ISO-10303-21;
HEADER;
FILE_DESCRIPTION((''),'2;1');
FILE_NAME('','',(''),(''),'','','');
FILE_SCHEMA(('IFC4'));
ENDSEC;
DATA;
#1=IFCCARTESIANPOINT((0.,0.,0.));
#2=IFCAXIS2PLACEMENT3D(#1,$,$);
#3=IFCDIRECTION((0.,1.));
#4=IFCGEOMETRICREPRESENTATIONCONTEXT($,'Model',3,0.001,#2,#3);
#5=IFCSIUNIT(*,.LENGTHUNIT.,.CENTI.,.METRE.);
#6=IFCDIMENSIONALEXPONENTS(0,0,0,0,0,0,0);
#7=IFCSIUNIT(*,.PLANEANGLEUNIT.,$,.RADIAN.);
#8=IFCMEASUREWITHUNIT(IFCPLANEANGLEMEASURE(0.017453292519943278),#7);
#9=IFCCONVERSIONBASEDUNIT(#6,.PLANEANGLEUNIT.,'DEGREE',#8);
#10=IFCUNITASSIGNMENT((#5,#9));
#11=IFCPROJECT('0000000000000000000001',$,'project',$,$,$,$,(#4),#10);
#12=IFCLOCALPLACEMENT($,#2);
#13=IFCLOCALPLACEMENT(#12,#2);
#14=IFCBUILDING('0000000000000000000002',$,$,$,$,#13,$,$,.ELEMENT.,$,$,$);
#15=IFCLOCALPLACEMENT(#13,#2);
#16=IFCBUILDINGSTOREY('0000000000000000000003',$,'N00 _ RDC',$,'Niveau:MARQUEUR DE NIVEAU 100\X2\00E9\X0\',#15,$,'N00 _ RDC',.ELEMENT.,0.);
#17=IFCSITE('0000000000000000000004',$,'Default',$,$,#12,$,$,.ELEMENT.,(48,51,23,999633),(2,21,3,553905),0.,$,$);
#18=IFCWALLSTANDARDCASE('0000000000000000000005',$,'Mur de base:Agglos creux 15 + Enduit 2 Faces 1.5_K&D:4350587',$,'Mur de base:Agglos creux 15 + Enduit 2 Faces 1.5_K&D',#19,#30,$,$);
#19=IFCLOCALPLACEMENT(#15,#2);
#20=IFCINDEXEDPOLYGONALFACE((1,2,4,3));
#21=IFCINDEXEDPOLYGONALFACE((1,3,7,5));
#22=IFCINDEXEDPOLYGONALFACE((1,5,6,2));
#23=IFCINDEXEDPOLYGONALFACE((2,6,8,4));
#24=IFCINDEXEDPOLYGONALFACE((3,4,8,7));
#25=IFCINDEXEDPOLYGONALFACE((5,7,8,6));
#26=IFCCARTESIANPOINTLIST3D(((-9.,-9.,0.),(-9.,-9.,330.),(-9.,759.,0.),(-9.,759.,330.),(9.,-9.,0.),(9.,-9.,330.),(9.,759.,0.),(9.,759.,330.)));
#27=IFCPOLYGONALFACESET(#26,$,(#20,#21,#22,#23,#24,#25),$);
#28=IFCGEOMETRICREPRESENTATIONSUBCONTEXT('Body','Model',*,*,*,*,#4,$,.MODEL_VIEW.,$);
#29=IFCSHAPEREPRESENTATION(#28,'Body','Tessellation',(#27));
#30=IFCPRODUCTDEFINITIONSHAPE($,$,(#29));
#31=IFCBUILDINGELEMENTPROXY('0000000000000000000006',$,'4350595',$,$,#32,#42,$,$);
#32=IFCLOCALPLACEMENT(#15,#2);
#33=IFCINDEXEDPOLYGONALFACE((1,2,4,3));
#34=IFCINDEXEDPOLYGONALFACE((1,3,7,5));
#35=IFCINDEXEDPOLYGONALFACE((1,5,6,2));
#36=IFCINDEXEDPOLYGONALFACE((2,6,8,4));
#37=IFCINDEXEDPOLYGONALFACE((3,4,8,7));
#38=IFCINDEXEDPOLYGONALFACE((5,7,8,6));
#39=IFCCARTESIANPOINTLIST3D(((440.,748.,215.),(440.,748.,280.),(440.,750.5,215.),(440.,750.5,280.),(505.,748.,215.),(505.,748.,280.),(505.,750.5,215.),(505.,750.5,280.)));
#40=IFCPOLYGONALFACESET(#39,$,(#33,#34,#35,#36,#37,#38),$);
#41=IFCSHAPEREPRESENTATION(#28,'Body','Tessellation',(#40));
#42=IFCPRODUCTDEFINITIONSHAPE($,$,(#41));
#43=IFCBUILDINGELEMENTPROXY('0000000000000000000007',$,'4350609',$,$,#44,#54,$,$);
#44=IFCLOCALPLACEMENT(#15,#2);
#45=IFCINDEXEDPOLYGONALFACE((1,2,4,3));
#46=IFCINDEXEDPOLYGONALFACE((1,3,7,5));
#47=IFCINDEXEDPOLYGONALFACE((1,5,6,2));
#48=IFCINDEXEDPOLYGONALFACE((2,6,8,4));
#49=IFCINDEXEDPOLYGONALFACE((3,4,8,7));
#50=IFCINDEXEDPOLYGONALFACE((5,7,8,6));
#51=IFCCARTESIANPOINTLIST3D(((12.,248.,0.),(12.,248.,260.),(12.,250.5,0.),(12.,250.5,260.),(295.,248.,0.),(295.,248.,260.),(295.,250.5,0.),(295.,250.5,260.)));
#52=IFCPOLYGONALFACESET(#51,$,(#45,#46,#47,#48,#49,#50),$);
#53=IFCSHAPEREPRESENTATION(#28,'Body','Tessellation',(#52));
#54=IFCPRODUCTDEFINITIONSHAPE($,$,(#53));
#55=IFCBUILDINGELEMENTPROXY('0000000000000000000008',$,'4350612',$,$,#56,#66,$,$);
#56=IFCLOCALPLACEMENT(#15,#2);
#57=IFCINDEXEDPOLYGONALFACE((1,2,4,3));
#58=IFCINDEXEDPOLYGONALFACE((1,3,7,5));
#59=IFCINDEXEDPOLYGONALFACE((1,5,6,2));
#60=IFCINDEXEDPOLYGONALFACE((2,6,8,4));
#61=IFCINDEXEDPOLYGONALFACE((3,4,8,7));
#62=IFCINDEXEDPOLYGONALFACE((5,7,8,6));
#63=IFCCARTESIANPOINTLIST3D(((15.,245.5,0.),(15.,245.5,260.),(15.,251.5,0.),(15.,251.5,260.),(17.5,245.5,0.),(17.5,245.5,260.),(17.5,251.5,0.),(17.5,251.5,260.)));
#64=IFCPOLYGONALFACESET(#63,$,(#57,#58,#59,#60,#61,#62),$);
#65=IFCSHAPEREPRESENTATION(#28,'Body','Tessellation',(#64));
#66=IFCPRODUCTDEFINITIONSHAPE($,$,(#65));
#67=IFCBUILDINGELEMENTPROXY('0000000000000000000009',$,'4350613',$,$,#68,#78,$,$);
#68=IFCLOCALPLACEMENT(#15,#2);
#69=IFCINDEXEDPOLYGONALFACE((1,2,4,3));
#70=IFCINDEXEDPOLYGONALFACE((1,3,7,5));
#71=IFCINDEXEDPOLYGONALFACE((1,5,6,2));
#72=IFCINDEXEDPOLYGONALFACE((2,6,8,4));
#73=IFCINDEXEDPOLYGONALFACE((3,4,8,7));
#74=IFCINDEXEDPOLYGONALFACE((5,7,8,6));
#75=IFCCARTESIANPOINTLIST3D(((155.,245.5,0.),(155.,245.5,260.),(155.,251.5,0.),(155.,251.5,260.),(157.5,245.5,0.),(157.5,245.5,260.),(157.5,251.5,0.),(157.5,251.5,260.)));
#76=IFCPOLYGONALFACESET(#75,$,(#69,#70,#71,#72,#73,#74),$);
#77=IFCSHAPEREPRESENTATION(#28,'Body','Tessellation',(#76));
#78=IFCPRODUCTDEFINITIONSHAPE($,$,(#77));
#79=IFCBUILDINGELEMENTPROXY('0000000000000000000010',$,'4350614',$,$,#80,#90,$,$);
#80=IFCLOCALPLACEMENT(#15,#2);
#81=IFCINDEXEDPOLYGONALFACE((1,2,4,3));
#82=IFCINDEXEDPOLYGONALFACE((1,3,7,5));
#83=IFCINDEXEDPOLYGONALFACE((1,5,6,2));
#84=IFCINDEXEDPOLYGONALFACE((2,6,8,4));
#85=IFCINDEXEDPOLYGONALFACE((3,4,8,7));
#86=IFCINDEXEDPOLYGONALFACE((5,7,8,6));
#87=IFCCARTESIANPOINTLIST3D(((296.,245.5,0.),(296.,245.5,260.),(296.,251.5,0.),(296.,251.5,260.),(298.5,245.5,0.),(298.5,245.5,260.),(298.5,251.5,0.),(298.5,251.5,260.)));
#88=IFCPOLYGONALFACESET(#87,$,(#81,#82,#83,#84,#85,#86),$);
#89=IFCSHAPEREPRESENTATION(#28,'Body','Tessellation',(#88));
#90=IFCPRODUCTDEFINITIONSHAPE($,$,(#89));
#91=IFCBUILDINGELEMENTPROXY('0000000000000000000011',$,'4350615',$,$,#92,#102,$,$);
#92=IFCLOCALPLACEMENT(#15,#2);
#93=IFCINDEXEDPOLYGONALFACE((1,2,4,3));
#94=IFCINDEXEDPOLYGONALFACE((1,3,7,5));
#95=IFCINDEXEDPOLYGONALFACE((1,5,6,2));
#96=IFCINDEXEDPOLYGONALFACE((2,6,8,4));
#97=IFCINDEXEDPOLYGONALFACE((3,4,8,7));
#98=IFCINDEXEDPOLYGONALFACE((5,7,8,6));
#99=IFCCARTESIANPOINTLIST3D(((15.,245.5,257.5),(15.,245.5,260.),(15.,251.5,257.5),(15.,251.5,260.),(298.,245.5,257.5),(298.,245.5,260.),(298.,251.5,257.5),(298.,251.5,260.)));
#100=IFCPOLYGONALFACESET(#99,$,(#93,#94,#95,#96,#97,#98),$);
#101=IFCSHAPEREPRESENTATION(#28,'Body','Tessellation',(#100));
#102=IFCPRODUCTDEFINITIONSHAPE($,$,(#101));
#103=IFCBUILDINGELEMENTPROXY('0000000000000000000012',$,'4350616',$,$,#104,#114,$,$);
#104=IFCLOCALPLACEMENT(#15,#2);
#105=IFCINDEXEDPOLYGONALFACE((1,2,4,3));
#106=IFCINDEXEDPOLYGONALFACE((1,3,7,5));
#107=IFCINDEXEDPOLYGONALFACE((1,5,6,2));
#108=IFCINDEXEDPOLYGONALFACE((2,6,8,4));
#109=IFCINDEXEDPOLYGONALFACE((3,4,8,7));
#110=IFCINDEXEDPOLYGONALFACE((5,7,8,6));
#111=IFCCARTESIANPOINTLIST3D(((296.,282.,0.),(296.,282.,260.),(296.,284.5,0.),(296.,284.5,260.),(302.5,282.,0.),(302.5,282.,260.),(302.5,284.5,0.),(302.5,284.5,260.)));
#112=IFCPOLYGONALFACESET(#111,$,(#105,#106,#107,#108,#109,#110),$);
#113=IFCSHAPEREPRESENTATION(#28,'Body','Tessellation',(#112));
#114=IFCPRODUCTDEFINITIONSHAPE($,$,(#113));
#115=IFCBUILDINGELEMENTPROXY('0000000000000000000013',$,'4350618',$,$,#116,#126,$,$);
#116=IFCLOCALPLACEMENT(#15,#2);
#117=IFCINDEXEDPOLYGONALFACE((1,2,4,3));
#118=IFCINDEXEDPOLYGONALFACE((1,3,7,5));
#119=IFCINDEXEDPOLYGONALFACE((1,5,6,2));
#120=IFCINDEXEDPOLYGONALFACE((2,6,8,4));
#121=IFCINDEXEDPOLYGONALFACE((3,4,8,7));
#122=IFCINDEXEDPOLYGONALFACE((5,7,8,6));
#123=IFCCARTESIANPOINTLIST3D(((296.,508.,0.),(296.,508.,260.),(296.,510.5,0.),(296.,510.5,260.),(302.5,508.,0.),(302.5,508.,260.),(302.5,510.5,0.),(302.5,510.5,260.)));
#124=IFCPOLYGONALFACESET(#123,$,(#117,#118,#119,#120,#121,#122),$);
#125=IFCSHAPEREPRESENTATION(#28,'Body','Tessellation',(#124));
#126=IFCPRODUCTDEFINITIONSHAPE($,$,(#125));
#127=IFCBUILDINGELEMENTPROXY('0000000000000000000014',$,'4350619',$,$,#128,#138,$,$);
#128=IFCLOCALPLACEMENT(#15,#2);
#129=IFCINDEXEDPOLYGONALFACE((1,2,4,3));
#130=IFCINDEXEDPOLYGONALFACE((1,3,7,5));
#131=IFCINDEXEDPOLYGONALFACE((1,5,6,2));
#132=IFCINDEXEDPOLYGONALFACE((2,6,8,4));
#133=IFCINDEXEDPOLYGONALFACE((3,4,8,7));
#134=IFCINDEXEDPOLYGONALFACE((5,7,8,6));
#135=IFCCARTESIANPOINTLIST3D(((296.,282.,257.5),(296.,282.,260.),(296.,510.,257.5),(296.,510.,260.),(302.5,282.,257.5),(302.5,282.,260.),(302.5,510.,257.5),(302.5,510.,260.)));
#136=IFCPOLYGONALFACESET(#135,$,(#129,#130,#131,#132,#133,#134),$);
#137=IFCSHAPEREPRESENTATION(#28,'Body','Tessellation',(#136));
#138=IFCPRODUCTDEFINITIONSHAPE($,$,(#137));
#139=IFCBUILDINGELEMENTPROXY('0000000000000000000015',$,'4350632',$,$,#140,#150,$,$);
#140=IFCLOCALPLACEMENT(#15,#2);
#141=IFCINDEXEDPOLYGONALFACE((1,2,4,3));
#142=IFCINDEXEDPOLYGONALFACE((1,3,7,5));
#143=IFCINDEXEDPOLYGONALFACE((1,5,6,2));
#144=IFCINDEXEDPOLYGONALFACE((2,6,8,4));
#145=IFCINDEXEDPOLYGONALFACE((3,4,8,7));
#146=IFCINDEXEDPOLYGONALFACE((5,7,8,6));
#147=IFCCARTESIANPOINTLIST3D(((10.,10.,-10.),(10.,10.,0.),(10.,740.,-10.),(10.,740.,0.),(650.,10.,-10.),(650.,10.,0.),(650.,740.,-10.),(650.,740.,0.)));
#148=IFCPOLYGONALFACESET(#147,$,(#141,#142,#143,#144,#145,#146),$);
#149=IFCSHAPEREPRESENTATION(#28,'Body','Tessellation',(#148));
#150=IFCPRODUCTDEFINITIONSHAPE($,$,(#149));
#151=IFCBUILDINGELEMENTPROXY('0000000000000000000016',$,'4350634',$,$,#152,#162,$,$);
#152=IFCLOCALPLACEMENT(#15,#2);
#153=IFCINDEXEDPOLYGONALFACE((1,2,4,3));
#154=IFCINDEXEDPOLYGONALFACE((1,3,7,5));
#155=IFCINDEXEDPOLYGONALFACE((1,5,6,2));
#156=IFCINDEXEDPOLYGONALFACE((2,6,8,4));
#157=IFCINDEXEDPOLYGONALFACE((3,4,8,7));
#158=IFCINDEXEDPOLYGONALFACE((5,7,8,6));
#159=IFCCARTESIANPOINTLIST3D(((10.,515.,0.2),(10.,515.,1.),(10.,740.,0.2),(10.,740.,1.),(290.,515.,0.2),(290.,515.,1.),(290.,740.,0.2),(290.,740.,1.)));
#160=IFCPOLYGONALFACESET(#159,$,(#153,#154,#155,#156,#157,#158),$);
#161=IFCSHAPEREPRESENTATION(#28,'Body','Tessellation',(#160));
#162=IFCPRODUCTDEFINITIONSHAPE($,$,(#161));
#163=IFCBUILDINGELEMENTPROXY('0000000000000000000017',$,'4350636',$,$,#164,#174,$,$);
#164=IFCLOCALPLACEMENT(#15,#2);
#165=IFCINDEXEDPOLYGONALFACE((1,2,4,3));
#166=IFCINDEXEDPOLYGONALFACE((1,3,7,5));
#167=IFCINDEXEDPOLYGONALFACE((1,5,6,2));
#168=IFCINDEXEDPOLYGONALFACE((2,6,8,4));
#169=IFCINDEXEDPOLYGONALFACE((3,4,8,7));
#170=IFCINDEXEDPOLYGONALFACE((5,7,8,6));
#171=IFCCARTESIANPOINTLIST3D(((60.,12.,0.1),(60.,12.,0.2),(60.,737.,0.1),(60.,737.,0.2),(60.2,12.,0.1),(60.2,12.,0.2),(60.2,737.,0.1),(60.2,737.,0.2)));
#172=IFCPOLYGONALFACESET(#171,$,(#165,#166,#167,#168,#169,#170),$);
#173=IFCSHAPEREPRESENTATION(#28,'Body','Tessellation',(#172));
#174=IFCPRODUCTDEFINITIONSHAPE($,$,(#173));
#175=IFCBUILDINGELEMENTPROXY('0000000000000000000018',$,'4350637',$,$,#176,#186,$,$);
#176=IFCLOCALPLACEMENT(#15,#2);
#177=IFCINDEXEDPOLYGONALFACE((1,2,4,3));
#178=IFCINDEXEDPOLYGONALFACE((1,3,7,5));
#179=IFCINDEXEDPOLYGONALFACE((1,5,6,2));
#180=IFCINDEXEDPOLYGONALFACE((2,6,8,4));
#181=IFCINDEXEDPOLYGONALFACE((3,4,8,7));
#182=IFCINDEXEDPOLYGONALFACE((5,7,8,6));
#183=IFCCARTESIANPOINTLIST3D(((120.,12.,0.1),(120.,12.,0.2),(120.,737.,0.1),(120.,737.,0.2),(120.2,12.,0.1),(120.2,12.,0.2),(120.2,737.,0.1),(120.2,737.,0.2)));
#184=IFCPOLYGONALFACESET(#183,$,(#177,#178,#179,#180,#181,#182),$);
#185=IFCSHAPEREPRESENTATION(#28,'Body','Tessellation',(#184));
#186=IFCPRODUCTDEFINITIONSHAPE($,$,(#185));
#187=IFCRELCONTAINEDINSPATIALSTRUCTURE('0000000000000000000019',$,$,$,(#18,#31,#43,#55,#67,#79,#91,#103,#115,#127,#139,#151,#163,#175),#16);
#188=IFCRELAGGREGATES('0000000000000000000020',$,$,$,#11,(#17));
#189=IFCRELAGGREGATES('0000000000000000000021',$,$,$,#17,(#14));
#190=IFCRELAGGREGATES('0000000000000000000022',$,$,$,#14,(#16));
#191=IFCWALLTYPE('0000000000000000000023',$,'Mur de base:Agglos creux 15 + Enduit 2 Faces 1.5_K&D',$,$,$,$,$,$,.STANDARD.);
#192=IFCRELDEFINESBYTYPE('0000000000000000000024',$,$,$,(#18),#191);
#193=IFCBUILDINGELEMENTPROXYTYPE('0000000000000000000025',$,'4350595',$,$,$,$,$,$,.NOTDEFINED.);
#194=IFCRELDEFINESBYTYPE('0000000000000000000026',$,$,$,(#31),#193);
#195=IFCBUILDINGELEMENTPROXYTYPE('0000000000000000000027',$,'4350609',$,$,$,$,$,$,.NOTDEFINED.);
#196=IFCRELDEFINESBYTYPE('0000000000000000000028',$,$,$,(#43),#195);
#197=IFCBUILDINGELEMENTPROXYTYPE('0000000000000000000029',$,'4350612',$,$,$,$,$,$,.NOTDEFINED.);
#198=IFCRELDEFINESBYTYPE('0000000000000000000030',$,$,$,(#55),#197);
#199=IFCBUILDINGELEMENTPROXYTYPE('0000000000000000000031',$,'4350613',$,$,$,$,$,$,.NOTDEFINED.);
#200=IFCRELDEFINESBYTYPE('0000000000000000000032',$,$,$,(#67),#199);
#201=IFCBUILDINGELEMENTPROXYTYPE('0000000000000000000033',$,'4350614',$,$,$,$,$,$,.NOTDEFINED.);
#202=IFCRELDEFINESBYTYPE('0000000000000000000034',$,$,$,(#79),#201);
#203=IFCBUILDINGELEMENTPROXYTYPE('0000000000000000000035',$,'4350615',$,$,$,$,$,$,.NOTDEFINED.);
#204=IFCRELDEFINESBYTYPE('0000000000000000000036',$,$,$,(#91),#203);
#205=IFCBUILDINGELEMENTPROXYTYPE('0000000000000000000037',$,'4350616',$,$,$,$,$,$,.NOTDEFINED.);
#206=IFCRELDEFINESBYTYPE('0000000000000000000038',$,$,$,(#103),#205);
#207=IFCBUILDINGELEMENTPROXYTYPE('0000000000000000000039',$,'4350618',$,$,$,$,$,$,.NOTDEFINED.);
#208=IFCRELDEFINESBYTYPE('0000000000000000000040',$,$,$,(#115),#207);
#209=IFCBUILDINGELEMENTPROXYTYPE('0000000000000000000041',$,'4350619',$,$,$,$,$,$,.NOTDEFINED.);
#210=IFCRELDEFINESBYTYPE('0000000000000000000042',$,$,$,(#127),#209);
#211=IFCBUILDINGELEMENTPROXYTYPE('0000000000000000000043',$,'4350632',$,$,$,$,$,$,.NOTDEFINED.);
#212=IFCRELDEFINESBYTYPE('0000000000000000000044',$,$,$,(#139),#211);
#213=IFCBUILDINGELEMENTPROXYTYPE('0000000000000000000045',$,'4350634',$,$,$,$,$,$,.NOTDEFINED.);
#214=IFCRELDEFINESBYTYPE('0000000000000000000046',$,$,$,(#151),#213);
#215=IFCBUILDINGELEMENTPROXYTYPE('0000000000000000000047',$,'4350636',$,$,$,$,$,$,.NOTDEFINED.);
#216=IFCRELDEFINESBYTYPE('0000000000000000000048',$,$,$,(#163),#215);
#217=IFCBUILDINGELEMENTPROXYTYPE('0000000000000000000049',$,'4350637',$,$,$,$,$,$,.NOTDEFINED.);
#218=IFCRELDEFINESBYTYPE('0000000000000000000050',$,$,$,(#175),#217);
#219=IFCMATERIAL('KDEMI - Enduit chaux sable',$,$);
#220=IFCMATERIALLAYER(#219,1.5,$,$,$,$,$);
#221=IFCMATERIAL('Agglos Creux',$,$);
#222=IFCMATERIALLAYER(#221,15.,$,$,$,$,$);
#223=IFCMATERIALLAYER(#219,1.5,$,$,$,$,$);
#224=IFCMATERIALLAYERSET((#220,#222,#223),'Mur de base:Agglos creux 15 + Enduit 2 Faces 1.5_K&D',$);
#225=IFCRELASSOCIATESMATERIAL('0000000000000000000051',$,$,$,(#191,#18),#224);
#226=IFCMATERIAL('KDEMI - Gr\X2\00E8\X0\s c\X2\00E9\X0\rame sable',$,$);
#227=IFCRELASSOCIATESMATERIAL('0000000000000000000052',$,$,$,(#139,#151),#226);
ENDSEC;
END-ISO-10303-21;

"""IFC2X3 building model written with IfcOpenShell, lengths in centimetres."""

from ifc_helpers import new_model, entity, si_unit, converted_unit, direction, frame, frame_2d, origin, origin_2d_with_axis, place, context, subcontext, project, spatial, rectangle, extrude, material, layer, layer_set, layer_usage, type_object, element, save


model = new_model("IFC2X3")

# Units and contexts
model_context = context("Model", 3, precision=0.001, world=origin(), true_north=direction((0.0, 1.0)))
body_context = subcontext(model_context, "Body", "Model", "MODEL_VIEW")
ifc_project = project(units=[si_unit("LENGTHUNIT", "METRE", prefix="CENTI"), converted_unit("PLANEANGLEUNIT", "DEGREE", entity("IfcPlaneAngleMeasure", 0.017453292519943278), si_unit("PLANEANGLEUNIT", "RADIAN"), dimensions=[0, 0, 0, 0, 0, 0, 0])], contexts=[model_context])

# Site, building, storey
site_placement = place(None, origin())
site = spatial("IfcSite", under=ifc_project, at=site_placement, Name="Default", CompositionType="ELEMENT", RefLatitude=(48, 51, 23, 999633), RefLongitude=(2, 21, 3, 553905), RefElevation=0.0)
building_placement = place(site_placement, origin())
building = spatial("IfcBuilding", under=site, at=building_placement, CompositionType="ELEMENT")
storey_placement = place(building_placement, origin())
storey = spatial("IfcBuildingStorey", under=building, at=storey_placement, Name="N00 _ RDC", ObjectType="Niveau:MARQUEUR DE NIVEAU 100é", LongName="N00 _ RDC", CompositionType="ELEMENT", Elevation=0.0)

# Wall
ifc_material_1 = material(Name="KDEMI - Enduit chaux sable")
ifc_layer_1 = layer(ifc_material_1, 1.5)
ifc_material_2 = material(Name="Agglos Creux")
ifc_layer_2 = layer(ifc_material_2, 15.0)
ifc_layer_3 = layer(ifc_material_1, 1.5)
ifc_layer_set = layer_set([ifc_layer_1, ifc_layer_2, ifc_layer_3], Name="Mur de base:Agglos creux 15 + Enduit 2 Faces 1.5_K&D")
ifc_layer_usage = layer_usage(ifc_layer_set, "AXIS2", "NEGATIVE", 9.0)
wall_type = type_object("IfcWallType", Name="Mur de base:Agglos creux 15 + Enduit 2 Faces 1.5_K&D", PredefinedType="STANDARD", material=ifc_layer_set)
wall_placement = place(storey_placement, frame((0.0, -9.0, 0.0), z_axis=(0.0, 0.0, 1.0), x_axis=(0.0, 1.0, 0.0)))
element("IfcWallStandardCase", 1, at=wall_placement, inside=storey, type_object=wall_type, material=ifc_layer_usage, Name="Mur de base:Agglos creux 15 + Enduit 2 Faces 1.5_K&D:4350587", ObjectType="Mur de base:Agglos creux 15 + Enduit 2 Faces 1.5_K&D", context=body_context, shape_type="SweptSolid", body=[
    extrude(rectangle(XDim=768.0, YDim=18.0, at=frame_2d((384.0, 0.0), x_axis=(-1.0, 0.0))), origin(), (0.0, 0.0, 1.0), 330.0),
])

# Building element proxies
building_element_proxy_type_1 = type_object("IfcBuildingElementProxyType", Name="4350595", PredefinedType="NOTDEFINED")
proxy_1_placement = place(storey_placement, origin())
element("IfcBuildingElementProxy", 2, at=proxy_1_placement, inside=storey, type_object=building_element_proxy_type_1, Name="4350595", context=body_context, shape_type="SweptSolid", body=[
    extrude(rectangle(XDim=65.0, YDim=2.5, at=frame_2d((0.0, 0.0), x_axis=(1.0, 0.0))), frame((472.5, 749.25, 215.0)), (0.0, 0.0, 1.0), 65.0),
])
building_element_proxy_type_2 = type_object("IfcBuildingElementProxyType", Name="4350609", PredefinedType="NOTDEFINED")
proxy_2_placement = place(storey_placement, origin())
element("IfcBuildingElementProxy", 3, at=proxy_2_placement, inside=storey, type_object=building_element_proxy_type_2, Name="4350609", context=body_context, shape_type="SweptSolid", body=[
    extrude(rectangle(XDim=283.0, YDim=2.5, at=frame_2d((0.0, 0.0), x_axis=(1.0, 0.0))), frame((153.5, 249.25, 0.0)), (0.0, 0.0, 1.0), 260.0),
])
building_element_proxy_type_3 = type_object("IfcBuildingElementProxyType", Name="4350612", PredefinedType="NOTDEFINED")
proxy_3_placement = place(storey_placement, origin())
element("IfcBuildingElementProxy", 4, at=proxy_3_placement, inside=storey, type_object=building_element_proxy_type_3, Name="4350612", context=body_context, shape_type="SweptSolid", body=[
    extrude(rectangle(XDim=2.5, YDim=6.0, at=frame_2d((0.0, 0.0), x_axis=(1.0, 0.0))), frame((16.25, 248.5, 0.0)), (0.0, 0.0, 1.0), 260.0),
])
building_element_proxy_type_4 = type_object("IfcBuildingElementProxyType", Name="4350613", PredefinedType="NOTDEFINED")
proxy_4_placement = place(storey_placement, origin())
element("IfcBuildingElementProxy", 5, at=proxy_4_placement, inside=storey, type_object=building_element_proxy_type_4, Name="4350613", context=body_context, shape_type="SweptSolid", body=[
    extrude(rectangle(XDim=2.5, YDim=6.0, at=frame_2d((0.0, 0.0), x_axis=(1.0, 0.0))), frame((156.25, 248.5, 0.0)), (0.0, 0.0, 1.0), 260.0),
])
building_element_proxy_type_5 = type_object("IfcBuildingElementProxyType", Name="4350614", PredefinedType="NOTDEFINED")
proxy_5_placement = place(storey_placement, origin())
element("IfcBuildingElementProxy", 6, at=proxy_5_placement, inside=storey, type_object=building_element_proxy_type_5, Name="4350614", context=body_context, shape_type="SweptSolid", body=[
    extrude(rectangle(XDim=2.5, YDim=6.0, at=frame_2d((0.0, 0.0), x_axis=(1.0, 0.0))), frame((297.25, 248.5, 0.0)), (0.0, 0.0, 1.0), 260.0),
])
building_element_proxy_type_6 = type_object("IfcBuildingElementProxyType", Name="4350615", PredefinedType="NOTDEFINED")
proxy_6_placement = place(storey_placement, origin())
element("IfcBuildingElementProxy", 7, at=proxy_6_placement, inside=storey, type_object=building_element_proxy_type_6, Name="4350615", context=body_context, shape_type="SweptSolid", body=[
    extrude(rectangle(XDim=283.0, YDim=6.0, at=frame_2d((0.0, 0.0), x_axis=(1.0, 0.0))), frame((156.5, 248.5, 257.5)), (0.0, 0.0, 1.0), 2.5),
])
building_element_proxy_type_7 = type_object("IfcBuildingElementProxyType", Name="4350616", PredefinedType="NOTDEFINED")
proxy_7_placement = place(storey_placement, origin())
element("IfcBuildingElementProxy", 8, at=proxy_7_placement, inside=storey, type_object=building_element_proxy_type_7, Name="4350616", context=body_context, shape_type="SweptSolid", body=[
    extrude(rectangle(XDim=6.5, YDim=2.5, at=frame_2d((0.0, 0.0), x_axis=(1.0, 0.0))), frame((299.25, 283.25, 0.0)), (0.0, 0.0, 1.0), 260.0),
])
building_element_proxy_type_8 = type_object("IfcBuildingElementProxyType", Name="4350618", PredefinedType="NOTDEFINED")
proxy_8_placement = place(storey_placement, origin())
element("IfcBuildingElementProxy", 9, at=proxy_8_placement, inside=storey, type_object=building_element_proxy_type_8, Name="4350618", context=body_context, shape_type="SweptSolid", body=[
    extrude(rectangle(XDim=6.5, YDim=2.5, at=frame_2d((0.0, 0.0), x_axis=(1.0, 0.0))), frame((299.25, 509.25, 0.0)), (0.0, 0.0, 1.0), 260.0),
])
building_element_proxy_type_9 = type_object("IfcBuildingElementProxyType", Name="4350619", PredefinedType="NOTDEFINED")
proxy_9_placement = place(storey_placement, origin())
element("IfcBuildingElementProxy", 10, at=proxy_9_placement, inside=storey, type_object=building_element_proxy_type_9, Name="4350619", context=body_context, shape_type="SweptSolid", body=[
    extrude(rectangle(XDim=6.5, YDim=228.0, at=frame_2d((0.0, 0.0), x_axis=(1.0, 0.0))), frame((299.25, 396.0, 257.5)), (0.0, 0.0, 1.0), 2.5),
])
ifc_material_3 = material(Name="KDEMI - Grès cérame sable")
building_element_proxy_type_10 = type_object("IfcBuildingElementProxyType", Name="4350632", PredefinedType="NOTDEFINED")
proxy_10_placement = place(storey_placement, origin())
element("IfcBuildingElementProxy", 11, at=proxy_10_placement, inside=storey, type_object=building_element_proxy_type_10, material=ifc_material_3, Name="4350632", context=body_context, shape_type="SweptSolid", body=[
    extrude(rectangle(XDim=640.0, YDim=730.0, at=origin_2d_with_axis()), frame((330.0, 375.0, -10.0)), (0.0, 0.0, 1.0), 10.0),
])
building_element_proxy_type_11 = type_object("IfcBuildingElementProxyType", Name="4350634", PredefinedType="NOTDEFINED")
proxy_11_placement = place(storey_placement, origin())
element("IfcBuildingElementProxy", 12, at=proxy_11_placement, inside=storey, type_object=building_element_proxy_type_11, material=ifc_material_3, Name="4350634", context=body_context, shape_type="SweptSolid", body=[
    extrude(rectangle(XDim=280.0, YDim=225.0, at=frame_2d((0.0, 0.0), x_axis=(1.0, 0.0))), frame((150.0, 627.5, 0.2)), (0.0, 0.0, 1.0), 0.8),
])
building_element_proxy_type_12 = type_object("IfcBuildingElementProxyType", Name="4350636", PredefinedType="NOTDEFINED")
proxy_12_placement = place(storey_placement, origin())
element("IfcBuildingElementProxy", 13, at=proxy_12_placement, inside=storey, type_object=building_element_proxy_type_12, Name="4350636", context=body_context, shape_type="SweptSolid", body=[
    extrude(rectangle(XDim=0.2, YDim=725.0, at=frame_2d((0.0, 0.0), x_axis=(1.0, 0.0))), frame((60.1, 374.5, 0.1)), (0.0, 0.0, 1.0), 0.1),
])
building_element_proxy_type_13 = type_object("IfcBuildingElementProxyType", Name="4350637", PredefinedType="NOTDEFINED")
proxy_13_placement = place(storey_placement, origin())
element("IfcBuildingElementProxy", 14, at=proxy_13_placement, inside=storey, type_object=building_element_proxy_type_13, Name="4350637", context=body_context, shape_type="SweptSolid", body=[
    extrude(rectangle(XDim=0.2, YDim=725.0, at=frame_2d((0.0, 0.0), x_axis=(1.0, 0.0))), frame((120.1, 374.5, 0.1)), (0.0, 0.0, 1.0), 0.1),
])

save(model, "model.ifc")
